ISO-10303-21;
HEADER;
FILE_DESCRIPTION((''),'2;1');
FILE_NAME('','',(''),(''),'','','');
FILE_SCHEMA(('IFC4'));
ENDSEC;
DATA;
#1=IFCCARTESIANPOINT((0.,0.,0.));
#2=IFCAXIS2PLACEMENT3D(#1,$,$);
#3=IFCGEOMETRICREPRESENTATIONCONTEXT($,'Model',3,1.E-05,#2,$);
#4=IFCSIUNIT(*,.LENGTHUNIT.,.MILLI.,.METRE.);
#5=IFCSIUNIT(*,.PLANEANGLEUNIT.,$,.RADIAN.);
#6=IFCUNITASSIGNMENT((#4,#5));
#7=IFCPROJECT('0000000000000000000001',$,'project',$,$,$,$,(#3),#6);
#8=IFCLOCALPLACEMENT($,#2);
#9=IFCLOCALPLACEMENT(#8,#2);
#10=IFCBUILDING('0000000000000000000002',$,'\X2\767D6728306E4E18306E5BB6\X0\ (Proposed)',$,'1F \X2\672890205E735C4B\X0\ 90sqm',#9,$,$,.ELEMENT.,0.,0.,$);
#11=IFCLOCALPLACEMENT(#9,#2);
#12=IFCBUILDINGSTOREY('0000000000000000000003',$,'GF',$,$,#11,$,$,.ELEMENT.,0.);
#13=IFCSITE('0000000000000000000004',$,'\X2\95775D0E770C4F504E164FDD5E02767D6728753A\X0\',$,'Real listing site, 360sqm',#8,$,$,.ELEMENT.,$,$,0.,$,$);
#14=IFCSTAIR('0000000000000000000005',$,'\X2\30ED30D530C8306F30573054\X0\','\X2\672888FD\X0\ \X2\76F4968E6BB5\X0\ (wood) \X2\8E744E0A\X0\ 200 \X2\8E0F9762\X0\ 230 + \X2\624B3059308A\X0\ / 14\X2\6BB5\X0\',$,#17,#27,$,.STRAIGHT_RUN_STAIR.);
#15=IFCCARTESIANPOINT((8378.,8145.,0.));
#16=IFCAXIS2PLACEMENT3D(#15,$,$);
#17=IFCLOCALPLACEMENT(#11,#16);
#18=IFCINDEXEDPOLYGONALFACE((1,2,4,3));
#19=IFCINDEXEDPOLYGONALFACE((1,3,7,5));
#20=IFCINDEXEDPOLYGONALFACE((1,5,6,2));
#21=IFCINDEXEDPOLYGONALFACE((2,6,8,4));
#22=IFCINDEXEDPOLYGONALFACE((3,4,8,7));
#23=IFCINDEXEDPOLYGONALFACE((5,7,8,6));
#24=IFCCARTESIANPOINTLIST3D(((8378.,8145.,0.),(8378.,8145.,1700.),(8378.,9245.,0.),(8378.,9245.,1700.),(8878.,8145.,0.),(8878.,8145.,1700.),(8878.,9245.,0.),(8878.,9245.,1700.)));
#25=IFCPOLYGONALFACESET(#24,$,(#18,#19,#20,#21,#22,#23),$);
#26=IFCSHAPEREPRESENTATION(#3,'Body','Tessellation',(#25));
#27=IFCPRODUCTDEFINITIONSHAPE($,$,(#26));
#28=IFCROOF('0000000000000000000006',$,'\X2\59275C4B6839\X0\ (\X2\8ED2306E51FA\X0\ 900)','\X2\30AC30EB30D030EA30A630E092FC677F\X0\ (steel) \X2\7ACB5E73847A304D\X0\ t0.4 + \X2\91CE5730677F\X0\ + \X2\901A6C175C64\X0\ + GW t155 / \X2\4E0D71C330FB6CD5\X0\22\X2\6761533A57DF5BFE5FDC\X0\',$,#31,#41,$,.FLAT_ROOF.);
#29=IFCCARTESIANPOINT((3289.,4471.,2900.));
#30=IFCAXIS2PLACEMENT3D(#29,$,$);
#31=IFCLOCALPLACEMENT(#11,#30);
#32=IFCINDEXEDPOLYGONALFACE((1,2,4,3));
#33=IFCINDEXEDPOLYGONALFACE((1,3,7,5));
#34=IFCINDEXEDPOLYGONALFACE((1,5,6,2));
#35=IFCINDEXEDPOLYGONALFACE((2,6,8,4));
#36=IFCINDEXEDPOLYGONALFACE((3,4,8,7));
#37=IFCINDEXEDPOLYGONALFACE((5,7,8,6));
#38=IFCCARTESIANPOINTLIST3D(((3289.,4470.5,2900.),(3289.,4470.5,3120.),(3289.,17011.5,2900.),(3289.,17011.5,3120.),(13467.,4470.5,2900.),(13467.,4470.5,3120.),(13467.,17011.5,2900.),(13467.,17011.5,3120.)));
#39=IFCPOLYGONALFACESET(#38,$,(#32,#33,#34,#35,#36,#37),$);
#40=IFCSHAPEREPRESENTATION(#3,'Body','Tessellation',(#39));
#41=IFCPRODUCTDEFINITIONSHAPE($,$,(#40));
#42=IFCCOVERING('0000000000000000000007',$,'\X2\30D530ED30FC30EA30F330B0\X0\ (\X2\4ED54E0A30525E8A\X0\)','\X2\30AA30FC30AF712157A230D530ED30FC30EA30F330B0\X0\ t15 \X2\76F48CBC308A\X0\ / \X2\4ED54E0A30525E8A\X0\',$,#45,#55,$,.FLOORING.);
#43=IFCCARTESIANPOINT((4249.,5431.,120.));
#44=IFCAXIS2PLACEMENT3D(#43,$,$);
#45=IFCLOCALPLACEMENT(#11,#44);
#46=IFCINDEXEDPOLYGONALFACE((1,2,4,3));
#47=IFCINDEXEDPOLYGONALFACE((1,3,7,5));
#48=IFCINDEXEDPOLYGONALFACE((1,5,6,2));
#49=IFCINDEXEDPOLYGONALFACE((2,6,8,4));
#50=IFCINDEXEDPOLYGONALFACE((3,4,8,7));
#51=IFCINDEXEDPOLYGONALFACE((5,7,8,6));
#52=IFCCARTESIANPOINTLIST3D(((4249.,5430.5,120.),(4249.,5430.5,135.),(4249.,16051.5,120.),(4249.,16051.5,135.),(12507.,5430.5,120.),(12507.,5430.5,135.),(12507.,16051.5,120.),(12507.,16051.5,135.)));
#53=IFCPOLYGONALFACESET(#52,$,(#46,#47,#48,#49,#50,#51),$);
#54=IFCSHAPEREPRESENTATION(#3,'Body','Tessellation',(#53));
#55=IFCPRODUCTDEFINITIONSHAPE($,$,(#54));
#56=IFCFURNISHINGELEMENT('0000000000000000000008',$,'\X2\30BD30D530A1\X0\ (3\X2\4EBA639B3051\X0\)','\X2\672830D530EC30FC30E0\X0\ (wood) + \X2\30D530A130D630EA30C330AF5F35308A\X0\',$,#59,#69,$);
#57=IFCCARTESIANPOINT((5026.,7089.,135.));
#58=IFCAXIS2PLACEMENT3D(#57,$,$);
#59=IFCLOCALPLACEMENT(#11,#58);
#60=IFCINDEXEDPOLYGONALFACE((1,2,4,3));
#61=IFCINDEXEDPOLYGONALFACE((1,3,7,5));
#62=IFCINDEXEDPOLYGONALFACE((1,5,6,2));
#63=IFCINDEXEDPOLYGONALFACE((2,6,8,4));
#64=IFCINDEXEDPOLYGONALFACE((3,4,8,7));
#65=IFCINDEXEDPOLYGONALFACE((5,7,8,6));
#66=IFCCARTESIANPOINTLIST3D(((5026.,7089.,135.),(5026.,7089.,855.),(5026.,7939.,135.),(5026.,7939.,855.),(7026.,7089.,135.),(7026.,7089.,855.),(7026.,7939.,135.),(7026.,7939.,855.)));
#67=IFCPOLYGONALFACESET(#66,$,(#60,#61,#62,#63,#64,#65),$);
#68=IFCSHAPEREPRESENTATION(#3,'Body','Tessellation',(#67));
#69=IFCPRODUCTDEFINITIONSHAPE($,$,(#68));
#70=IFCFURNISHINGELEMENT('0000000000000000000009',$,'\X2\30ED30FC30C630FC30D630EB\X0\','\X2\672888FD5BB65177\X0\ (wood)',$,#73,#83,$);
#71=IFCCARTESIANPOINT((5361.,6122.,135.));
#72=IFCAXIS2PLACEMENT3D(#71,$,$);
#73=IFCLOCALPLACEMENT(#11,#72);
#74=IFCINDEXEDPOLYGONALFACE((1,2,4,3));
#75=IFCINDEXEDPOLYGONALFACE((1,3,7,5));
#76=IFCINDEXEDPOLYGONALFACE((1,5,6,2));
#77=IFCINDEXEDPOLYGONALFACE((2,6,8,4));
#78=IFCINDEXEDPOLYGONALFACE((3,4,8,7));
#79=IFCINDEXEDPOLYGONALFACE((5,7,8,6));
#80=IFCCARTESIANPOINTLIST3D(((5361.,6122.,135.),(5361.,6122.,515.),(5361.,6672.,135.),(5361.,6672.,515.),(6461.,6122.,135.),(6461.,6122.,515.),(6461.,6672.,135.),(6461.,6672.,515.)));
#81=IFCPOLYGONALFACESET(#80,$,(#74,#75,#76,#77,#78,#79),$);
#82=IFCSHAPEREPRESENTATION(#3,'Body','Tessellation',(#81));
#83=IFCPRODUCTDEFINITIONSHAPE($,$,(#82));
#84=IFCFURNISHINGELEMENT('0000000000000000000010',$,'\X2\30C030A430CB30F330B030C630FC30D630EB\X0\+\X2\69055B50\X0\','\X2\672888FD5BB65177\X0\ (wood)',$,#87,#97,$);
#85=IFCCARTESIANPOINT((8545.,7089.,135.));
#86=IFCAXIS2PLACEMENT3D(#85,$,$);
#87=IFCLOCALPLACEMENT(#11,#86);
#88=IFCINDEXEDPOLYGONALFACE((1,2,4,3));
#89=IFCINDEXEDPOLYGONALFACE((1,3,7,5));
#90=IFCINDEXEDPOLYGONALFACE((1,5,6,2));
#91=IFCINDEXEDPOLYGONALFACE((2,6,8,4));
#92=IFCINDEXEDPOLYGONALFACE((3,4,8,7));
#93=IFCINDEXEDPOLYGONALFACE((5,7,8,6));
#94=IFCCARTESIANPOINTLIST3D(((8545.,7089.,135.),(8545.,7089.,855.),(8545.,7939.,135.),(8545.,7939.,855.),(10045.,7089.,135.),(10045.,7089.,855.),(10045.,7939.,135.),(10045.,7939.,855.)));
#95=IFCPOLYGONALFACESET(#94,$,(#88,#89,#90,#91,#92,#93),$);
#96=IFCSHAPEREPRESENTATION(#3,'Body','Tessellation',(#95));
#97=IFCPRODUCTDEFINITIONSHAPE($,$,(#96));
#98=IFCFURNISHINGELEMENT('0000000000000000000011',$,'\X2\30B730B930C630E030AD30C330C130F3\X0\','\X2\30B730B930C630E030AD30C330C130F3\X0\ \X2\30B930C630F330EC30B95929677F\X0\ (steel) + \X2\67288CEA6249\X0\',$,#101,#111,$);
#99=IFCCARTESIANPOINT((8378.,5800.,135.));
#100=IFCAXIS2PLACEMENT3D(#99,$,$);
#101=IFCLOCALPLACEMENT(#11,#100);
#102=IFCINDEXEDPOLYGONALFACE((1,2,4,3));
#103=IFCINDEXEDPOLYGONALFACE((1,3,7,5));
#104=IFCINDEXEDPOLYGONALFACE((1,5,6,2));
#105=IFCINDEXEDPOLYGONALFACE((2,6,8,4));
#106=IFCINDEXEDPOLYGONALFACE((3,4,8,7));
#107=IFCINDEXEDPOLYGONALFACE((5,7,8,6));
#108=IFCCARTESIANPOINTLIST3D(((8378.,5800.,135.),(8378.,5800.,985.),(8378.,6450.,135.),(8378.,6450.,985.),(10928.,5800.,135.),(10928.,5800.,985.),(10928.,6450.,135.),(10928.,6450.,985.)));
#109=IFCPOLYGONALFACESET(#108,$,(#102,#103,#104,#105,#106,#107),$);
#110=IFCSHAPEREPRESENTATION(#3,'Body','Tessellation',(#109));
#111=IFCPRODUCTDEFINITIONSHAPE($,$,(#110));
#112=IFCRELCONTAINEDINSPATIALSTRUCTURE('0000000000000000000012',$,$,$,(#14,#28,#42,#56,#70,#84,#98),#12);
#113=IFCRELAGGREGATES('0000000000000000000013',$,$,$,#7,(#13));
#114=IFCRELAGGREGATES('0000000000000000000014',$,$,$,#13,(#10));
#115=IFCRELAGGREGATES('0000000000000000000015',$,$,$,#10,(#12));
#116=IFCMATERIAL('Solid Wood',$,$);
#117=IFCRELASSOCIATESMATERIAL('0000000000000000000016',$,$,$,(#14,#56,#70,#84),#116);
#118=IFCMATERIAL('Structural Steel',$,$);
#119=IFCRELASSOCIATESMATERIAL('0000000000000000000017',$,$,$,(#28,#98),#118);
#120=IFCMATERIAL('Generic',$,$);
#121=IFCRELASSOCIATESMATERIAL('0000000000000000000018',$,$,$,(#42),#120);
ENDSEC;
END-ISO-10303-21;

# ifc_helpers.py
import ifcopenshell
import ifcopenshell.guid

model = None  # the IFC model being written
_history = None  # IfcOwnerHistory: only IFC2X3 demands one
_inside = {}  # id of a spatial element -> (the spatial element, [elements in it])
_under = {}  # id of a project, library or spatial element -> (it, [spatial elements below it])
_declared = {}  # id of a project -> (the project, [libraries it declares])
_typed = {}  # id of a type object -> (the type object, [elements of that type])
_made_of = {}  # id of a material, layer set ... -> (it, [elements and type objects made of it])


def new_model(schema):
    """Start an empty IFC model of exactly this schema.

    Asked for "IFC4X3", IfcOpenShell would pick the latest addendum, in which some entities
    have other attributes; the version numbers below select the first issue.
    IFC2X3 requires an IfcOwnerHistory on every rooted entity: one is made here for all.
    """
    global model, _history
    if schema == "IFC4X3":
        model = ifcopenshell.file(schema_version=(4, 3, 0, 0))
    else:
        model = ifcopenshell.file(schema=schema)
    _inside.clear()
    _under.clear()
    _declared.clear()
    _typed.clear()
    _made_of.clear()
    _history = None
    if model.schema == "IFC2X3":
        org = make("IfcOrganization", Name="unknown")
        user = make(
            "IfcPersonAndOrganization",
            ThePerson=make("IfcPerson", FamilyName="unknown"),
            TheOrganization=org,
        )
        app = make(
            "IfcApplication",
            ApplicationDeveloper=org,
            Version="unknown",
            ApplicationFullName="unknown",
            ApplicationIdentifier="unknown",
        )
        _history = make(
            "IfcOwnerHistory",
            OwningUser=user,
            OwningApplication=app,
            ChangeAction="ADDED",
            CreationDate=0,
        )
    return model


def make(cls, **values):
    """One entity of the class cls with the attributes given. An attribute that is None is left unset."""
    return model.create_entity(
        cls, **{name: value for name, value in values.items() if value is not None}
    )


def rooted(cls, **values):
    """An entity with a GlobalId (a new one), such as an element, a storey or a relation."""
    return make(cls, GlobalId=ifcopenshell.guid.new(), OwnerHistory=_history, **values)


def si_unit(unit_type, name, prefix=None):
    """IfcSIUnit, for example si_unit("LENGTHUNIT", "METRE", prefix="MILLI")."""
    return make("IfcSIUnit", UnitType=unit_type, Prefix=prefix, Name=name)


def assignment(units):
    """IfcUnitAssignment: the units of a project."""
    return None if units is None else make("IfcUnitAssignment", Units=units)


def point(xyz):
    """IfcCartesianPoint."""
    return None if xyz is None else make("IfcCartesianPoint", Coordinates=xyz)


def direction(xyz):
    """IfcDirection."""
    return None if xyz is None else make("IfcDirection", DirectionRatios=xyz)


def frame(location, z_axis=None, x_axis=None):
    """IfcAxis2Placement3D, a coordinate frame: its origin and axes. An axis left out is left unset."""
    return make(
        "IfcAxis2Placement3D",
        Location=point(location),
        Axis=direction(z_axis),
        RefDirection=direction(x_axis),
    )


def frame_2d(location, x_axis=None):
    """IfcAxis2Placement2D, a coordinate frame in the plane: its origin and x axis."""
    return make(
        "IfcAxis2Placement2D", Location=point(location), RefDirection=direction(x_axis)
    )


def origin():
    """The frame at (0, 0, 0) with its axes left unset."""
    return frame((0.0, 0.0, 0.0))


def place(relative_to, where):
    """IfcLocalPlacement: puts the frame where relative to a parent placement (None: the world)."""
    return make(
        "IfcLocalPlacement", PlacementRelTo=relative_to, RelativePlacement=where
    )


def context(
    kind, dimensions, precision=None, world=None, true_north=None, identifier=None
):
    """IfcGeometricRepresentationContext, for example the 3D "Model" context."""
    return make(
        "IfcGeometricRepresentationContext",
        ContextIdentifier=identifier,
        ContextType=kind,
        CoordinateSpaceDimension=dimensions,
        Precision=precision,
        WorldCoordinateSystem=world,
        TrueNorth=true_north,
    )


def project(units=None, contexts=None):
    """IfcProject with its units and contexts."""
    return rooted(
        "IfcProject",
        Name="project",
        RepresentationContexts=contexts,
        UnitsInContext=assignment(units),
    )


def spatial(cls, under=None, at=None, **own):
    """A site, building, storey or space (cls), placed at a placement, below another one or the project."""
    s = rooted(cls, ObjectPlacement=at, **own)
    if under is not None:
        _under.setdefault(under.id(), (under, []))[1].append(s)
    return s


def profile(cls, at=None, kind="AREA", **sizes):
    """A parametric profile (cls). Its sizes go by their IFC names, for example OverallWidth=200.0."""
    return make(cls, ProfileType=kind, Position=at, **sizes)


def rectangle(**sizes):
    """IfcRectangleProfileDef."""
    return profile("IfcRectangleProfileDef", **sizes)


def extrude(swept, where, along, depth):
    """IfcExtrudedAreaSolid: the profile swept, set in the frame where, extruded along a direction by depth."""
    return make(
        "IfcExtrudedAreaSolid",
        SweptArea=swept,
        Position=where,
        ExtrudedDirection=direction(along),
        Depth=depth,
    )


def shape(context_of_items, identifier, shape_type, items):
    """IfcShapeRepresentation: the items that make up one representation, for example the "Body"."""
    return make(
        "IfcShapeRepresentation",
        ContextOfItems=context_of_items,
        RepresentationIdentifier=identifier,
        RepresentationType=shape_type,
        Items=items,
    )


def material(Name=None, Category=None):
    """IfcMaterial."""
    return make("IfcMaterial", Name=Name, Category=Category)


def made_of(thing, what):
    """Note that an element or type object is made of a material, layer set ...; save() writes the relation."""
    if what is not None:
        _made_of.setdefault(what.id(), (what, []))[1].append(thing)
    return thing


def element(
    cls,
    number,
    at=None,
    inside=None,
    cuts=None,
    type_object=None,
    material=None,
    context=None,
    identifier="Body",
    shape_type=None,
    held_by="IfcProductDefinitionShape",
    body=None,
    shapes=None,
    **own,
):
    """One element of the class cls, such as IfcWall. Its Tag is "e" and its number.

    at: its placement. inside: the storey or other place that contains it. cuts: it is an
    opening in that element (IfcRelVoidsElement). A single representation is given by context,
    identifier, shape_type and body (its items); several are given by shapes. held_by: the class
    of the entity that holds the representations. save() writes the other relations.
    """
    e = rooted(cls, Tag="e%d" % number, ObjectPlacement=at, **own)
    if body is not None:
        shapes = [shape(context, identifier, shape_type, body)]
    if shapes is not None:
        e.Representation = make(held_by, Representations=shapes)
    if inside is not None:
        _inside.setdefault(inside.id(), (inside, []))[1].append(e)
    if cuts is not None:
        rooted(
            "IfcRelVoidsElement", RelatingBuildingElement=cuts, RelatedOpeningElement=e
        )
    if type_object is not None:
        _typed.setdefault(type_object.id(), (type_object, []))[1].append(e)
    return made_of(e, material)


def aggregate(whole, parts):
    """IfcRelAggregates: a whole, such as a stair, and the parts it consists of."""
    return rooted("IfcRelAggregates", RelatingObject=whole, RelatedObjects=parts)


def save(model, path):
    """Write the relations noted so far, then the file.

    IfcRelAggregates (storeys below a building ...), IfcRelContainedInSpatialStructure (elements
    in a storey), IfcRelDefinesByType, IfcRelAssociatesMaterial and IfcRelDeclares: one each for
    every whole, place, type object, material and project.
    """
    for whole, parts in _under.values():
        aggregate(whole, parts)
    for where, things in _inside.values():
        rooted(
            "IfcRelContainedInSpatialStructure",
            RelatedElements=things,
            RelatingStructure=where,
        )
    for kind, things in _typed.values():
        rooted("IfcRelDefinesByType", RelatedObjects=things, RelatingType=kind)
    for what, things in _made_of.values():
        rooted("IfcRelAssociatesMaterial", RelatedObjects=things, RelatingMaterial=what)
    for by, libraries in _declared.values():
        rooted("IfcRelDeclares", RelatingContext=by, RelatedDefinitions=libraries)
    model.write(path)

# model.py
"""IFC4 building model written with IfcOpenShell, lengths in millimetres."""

from ifc_helpers import new_model, si_unit, frame, frame_2d, origin, place, context, project, spatial, rectangle, extrude, material, element, save


model = new_model("IFC4")

# Units and contexts
model_context = context("Model", 3, precision=1e-05, world=origin())
ifc_project = project(units=[si_unit("LENGTHUNIT", "METRE", prefix="MILLI"), si_unit("PLANEANGLEUNIT", "RADIAN")], contexts=[model_context])

# Site, building, storey
site_placement = place(None, origin())
site = spatial("IfcSite", under=ifc_project, at=site_placement, Name="長崎県佐世保市白木町", ObjectType="Real listing site, 360sqm", CompositionType="ELEMENT", RefElevation=0.0)
building_placement = place(site_placement, origin())
building = spatial("IfcBuilding", under=site, at=building_placement, Name="白木の丘の家 (Proposed)", ObjectType="1F 木造平屋 90sqm", CompositionType="ELEMENT", ElevationOfRefHeight=0.0, ElevationOfTerrain=0.0)
storey_placement = place(building_placement, origin())
storey = spatial("IfcBuildingStorey", under=building, at=storey_placement, Name="GF", CompositionType="ELEMENT", Elevation=0.0)

# Shared definitions
ifc_material_1 = material(Name="Solid Wood")

# Stair
stair_placement = place(storey_placement, frame((8378.0, 8145.0, 0.0)))
element("IfcStair", 1, at=stair_placement, inside=storey, material=ifc_material_1, Name="ロフトはしご", Description="木製 直階段 (wood) 蹴上 200 踏面 230 + 手すり / 14段", PredefinedType="STRAIGHT_RUN_STAIR", context=model_context, shape_type="SweptSolid", body=[
    extrude(rectangle(XDim=500.0, YDim=1100.0, at=frame_2d((250.0, 550.0))), frame((8378.0, 8145.0, 0.0)), (0.0, 0.0, 1.0), 1700.0),
])

# Roof
ifc_material_2 = material(Name="Structural Steel")
roof_placement = place(storey_placement, frame((3289.0, 4471.0, 2900.0)))
element("IfcRoof", 2, at=roof_placement, inside=storey, material=ifc_material_2, Name="大屋根 (軒の出 900)", Description="ガルバリウム鋼板 (steel) 立平葺き t0.4 + 野地板 + 通気層 + GW t155 / 不燃・法22条区域対応", PredefinedType="FLAT_ROOF", context=model_context, shape_type="SweptSolid", body=[
    extrude(rectangle(XDim=10178.0, YDim=12541.0, at=frame_2d((5089.0, 6270.0))), frame((3289.0, 4471.0, 2900.0)), (0.0, 0.0, 1.0), 220.0),
])

# Covering
ifc_material_3 = material(Name="Generic")
covering_placement = place(storey_placement, frame((4249.0, 5431.0, 120.0)))
element("IfcCovering", 3, at=covering_placement, inside=storey, material=ifc_material_3, Name="フローリング (仕上げ床)", Description="オーク無垢フローリング t15 直貼り / 仕上げ床", PredefinedType="FLOORING", context=model_context, shape_type="SweptSolid", body=[
    extrude(rectangle(XDim=8258.0, YDim=10621.0, at=frame_2d((4129.0, 5310.0))), frame((4249.0, 5431.0, 120.0)), (0.0, 0.0, 1.0), 15.0),
])

# Furnishing elements
furnishing_1_placement = place(storey_placement, frame((5026.0, 7089.0, 135.0)))
element("IfcFurnishingElement", 4, at=furnishing_1_placement, inside=storey, material=ifc_material_1, Name="ソファ (3人掛け)", Description="木フレーム (wood) + ファブリック張り", context=model_context, shape_type="SweptSolid", body=[
    extrude(rectangle(XDim=2000.0, YDim=850.0, at=frame_2d((1000.0, 425.0))), frame((5026.0, 7089.0, 135.0)), (0.0, 0.0, 1.0), 720.0),
])
furnishing_2_placement = place(storey_placement, frame((5361.0, 6122.0, 135.0)))
element("IfcFurnishingElement", 5, at=furnishing_2_placement, inside=storey, material=ifc_material_1, Name="ローテーブル", Description="木製家具 (wood)", context=model_context, shape_type="SweptSolid", body=[
    extrude(rectangle(XDim=1100.0, YDim=550.0, at=frame_2d((550.0, 275.0))), frame((5361.0, 6122.0, 135.0)), (0.0, 0.0, 1.0), 380.0),
])
furnishing_3_placement = place(storey_placement, frame((8545.0, 7089.0, 135.0)))
element("IfcFurnishingElement", 6, at=furnishing_3_placement, inside=storey, material=ifc_material_1, Name="ダイニングテーブル+椅子", Description="木製家具 (wood)", context=model_context, shape_type="SweptSolid", body=[
    extrude(rectangle(XDim=1500.0, YDim=850.0, at=frame_2d((750.0, 425.0))), frame((8545.0, 7089.0, 135.0)), (0.0, 0.0, 1.0), 720.0),
])
furnishing_4_placement = place(storey_placement, frame((8378.0, 5800.0, 135.0)))
element("IfcFurnishingElement", 7, at=furnishing_4_placement, inside=storey, material=ifc_material_2, Name="システムキッチン", Description="システムキッチン ステンレス天板 (steel) + 木質扉", context=model_context, shape_type="SweptSolid", body=[
    extrude(rectangle(XDim=2550.0, YDim=650.0, at=frame_2d((1275.0, 325.0))), frame((8378.0, 5800.0, 135.0)), (0.0, 0.0, 1.0), 850.0),
])

save(model, "model.ifc")
